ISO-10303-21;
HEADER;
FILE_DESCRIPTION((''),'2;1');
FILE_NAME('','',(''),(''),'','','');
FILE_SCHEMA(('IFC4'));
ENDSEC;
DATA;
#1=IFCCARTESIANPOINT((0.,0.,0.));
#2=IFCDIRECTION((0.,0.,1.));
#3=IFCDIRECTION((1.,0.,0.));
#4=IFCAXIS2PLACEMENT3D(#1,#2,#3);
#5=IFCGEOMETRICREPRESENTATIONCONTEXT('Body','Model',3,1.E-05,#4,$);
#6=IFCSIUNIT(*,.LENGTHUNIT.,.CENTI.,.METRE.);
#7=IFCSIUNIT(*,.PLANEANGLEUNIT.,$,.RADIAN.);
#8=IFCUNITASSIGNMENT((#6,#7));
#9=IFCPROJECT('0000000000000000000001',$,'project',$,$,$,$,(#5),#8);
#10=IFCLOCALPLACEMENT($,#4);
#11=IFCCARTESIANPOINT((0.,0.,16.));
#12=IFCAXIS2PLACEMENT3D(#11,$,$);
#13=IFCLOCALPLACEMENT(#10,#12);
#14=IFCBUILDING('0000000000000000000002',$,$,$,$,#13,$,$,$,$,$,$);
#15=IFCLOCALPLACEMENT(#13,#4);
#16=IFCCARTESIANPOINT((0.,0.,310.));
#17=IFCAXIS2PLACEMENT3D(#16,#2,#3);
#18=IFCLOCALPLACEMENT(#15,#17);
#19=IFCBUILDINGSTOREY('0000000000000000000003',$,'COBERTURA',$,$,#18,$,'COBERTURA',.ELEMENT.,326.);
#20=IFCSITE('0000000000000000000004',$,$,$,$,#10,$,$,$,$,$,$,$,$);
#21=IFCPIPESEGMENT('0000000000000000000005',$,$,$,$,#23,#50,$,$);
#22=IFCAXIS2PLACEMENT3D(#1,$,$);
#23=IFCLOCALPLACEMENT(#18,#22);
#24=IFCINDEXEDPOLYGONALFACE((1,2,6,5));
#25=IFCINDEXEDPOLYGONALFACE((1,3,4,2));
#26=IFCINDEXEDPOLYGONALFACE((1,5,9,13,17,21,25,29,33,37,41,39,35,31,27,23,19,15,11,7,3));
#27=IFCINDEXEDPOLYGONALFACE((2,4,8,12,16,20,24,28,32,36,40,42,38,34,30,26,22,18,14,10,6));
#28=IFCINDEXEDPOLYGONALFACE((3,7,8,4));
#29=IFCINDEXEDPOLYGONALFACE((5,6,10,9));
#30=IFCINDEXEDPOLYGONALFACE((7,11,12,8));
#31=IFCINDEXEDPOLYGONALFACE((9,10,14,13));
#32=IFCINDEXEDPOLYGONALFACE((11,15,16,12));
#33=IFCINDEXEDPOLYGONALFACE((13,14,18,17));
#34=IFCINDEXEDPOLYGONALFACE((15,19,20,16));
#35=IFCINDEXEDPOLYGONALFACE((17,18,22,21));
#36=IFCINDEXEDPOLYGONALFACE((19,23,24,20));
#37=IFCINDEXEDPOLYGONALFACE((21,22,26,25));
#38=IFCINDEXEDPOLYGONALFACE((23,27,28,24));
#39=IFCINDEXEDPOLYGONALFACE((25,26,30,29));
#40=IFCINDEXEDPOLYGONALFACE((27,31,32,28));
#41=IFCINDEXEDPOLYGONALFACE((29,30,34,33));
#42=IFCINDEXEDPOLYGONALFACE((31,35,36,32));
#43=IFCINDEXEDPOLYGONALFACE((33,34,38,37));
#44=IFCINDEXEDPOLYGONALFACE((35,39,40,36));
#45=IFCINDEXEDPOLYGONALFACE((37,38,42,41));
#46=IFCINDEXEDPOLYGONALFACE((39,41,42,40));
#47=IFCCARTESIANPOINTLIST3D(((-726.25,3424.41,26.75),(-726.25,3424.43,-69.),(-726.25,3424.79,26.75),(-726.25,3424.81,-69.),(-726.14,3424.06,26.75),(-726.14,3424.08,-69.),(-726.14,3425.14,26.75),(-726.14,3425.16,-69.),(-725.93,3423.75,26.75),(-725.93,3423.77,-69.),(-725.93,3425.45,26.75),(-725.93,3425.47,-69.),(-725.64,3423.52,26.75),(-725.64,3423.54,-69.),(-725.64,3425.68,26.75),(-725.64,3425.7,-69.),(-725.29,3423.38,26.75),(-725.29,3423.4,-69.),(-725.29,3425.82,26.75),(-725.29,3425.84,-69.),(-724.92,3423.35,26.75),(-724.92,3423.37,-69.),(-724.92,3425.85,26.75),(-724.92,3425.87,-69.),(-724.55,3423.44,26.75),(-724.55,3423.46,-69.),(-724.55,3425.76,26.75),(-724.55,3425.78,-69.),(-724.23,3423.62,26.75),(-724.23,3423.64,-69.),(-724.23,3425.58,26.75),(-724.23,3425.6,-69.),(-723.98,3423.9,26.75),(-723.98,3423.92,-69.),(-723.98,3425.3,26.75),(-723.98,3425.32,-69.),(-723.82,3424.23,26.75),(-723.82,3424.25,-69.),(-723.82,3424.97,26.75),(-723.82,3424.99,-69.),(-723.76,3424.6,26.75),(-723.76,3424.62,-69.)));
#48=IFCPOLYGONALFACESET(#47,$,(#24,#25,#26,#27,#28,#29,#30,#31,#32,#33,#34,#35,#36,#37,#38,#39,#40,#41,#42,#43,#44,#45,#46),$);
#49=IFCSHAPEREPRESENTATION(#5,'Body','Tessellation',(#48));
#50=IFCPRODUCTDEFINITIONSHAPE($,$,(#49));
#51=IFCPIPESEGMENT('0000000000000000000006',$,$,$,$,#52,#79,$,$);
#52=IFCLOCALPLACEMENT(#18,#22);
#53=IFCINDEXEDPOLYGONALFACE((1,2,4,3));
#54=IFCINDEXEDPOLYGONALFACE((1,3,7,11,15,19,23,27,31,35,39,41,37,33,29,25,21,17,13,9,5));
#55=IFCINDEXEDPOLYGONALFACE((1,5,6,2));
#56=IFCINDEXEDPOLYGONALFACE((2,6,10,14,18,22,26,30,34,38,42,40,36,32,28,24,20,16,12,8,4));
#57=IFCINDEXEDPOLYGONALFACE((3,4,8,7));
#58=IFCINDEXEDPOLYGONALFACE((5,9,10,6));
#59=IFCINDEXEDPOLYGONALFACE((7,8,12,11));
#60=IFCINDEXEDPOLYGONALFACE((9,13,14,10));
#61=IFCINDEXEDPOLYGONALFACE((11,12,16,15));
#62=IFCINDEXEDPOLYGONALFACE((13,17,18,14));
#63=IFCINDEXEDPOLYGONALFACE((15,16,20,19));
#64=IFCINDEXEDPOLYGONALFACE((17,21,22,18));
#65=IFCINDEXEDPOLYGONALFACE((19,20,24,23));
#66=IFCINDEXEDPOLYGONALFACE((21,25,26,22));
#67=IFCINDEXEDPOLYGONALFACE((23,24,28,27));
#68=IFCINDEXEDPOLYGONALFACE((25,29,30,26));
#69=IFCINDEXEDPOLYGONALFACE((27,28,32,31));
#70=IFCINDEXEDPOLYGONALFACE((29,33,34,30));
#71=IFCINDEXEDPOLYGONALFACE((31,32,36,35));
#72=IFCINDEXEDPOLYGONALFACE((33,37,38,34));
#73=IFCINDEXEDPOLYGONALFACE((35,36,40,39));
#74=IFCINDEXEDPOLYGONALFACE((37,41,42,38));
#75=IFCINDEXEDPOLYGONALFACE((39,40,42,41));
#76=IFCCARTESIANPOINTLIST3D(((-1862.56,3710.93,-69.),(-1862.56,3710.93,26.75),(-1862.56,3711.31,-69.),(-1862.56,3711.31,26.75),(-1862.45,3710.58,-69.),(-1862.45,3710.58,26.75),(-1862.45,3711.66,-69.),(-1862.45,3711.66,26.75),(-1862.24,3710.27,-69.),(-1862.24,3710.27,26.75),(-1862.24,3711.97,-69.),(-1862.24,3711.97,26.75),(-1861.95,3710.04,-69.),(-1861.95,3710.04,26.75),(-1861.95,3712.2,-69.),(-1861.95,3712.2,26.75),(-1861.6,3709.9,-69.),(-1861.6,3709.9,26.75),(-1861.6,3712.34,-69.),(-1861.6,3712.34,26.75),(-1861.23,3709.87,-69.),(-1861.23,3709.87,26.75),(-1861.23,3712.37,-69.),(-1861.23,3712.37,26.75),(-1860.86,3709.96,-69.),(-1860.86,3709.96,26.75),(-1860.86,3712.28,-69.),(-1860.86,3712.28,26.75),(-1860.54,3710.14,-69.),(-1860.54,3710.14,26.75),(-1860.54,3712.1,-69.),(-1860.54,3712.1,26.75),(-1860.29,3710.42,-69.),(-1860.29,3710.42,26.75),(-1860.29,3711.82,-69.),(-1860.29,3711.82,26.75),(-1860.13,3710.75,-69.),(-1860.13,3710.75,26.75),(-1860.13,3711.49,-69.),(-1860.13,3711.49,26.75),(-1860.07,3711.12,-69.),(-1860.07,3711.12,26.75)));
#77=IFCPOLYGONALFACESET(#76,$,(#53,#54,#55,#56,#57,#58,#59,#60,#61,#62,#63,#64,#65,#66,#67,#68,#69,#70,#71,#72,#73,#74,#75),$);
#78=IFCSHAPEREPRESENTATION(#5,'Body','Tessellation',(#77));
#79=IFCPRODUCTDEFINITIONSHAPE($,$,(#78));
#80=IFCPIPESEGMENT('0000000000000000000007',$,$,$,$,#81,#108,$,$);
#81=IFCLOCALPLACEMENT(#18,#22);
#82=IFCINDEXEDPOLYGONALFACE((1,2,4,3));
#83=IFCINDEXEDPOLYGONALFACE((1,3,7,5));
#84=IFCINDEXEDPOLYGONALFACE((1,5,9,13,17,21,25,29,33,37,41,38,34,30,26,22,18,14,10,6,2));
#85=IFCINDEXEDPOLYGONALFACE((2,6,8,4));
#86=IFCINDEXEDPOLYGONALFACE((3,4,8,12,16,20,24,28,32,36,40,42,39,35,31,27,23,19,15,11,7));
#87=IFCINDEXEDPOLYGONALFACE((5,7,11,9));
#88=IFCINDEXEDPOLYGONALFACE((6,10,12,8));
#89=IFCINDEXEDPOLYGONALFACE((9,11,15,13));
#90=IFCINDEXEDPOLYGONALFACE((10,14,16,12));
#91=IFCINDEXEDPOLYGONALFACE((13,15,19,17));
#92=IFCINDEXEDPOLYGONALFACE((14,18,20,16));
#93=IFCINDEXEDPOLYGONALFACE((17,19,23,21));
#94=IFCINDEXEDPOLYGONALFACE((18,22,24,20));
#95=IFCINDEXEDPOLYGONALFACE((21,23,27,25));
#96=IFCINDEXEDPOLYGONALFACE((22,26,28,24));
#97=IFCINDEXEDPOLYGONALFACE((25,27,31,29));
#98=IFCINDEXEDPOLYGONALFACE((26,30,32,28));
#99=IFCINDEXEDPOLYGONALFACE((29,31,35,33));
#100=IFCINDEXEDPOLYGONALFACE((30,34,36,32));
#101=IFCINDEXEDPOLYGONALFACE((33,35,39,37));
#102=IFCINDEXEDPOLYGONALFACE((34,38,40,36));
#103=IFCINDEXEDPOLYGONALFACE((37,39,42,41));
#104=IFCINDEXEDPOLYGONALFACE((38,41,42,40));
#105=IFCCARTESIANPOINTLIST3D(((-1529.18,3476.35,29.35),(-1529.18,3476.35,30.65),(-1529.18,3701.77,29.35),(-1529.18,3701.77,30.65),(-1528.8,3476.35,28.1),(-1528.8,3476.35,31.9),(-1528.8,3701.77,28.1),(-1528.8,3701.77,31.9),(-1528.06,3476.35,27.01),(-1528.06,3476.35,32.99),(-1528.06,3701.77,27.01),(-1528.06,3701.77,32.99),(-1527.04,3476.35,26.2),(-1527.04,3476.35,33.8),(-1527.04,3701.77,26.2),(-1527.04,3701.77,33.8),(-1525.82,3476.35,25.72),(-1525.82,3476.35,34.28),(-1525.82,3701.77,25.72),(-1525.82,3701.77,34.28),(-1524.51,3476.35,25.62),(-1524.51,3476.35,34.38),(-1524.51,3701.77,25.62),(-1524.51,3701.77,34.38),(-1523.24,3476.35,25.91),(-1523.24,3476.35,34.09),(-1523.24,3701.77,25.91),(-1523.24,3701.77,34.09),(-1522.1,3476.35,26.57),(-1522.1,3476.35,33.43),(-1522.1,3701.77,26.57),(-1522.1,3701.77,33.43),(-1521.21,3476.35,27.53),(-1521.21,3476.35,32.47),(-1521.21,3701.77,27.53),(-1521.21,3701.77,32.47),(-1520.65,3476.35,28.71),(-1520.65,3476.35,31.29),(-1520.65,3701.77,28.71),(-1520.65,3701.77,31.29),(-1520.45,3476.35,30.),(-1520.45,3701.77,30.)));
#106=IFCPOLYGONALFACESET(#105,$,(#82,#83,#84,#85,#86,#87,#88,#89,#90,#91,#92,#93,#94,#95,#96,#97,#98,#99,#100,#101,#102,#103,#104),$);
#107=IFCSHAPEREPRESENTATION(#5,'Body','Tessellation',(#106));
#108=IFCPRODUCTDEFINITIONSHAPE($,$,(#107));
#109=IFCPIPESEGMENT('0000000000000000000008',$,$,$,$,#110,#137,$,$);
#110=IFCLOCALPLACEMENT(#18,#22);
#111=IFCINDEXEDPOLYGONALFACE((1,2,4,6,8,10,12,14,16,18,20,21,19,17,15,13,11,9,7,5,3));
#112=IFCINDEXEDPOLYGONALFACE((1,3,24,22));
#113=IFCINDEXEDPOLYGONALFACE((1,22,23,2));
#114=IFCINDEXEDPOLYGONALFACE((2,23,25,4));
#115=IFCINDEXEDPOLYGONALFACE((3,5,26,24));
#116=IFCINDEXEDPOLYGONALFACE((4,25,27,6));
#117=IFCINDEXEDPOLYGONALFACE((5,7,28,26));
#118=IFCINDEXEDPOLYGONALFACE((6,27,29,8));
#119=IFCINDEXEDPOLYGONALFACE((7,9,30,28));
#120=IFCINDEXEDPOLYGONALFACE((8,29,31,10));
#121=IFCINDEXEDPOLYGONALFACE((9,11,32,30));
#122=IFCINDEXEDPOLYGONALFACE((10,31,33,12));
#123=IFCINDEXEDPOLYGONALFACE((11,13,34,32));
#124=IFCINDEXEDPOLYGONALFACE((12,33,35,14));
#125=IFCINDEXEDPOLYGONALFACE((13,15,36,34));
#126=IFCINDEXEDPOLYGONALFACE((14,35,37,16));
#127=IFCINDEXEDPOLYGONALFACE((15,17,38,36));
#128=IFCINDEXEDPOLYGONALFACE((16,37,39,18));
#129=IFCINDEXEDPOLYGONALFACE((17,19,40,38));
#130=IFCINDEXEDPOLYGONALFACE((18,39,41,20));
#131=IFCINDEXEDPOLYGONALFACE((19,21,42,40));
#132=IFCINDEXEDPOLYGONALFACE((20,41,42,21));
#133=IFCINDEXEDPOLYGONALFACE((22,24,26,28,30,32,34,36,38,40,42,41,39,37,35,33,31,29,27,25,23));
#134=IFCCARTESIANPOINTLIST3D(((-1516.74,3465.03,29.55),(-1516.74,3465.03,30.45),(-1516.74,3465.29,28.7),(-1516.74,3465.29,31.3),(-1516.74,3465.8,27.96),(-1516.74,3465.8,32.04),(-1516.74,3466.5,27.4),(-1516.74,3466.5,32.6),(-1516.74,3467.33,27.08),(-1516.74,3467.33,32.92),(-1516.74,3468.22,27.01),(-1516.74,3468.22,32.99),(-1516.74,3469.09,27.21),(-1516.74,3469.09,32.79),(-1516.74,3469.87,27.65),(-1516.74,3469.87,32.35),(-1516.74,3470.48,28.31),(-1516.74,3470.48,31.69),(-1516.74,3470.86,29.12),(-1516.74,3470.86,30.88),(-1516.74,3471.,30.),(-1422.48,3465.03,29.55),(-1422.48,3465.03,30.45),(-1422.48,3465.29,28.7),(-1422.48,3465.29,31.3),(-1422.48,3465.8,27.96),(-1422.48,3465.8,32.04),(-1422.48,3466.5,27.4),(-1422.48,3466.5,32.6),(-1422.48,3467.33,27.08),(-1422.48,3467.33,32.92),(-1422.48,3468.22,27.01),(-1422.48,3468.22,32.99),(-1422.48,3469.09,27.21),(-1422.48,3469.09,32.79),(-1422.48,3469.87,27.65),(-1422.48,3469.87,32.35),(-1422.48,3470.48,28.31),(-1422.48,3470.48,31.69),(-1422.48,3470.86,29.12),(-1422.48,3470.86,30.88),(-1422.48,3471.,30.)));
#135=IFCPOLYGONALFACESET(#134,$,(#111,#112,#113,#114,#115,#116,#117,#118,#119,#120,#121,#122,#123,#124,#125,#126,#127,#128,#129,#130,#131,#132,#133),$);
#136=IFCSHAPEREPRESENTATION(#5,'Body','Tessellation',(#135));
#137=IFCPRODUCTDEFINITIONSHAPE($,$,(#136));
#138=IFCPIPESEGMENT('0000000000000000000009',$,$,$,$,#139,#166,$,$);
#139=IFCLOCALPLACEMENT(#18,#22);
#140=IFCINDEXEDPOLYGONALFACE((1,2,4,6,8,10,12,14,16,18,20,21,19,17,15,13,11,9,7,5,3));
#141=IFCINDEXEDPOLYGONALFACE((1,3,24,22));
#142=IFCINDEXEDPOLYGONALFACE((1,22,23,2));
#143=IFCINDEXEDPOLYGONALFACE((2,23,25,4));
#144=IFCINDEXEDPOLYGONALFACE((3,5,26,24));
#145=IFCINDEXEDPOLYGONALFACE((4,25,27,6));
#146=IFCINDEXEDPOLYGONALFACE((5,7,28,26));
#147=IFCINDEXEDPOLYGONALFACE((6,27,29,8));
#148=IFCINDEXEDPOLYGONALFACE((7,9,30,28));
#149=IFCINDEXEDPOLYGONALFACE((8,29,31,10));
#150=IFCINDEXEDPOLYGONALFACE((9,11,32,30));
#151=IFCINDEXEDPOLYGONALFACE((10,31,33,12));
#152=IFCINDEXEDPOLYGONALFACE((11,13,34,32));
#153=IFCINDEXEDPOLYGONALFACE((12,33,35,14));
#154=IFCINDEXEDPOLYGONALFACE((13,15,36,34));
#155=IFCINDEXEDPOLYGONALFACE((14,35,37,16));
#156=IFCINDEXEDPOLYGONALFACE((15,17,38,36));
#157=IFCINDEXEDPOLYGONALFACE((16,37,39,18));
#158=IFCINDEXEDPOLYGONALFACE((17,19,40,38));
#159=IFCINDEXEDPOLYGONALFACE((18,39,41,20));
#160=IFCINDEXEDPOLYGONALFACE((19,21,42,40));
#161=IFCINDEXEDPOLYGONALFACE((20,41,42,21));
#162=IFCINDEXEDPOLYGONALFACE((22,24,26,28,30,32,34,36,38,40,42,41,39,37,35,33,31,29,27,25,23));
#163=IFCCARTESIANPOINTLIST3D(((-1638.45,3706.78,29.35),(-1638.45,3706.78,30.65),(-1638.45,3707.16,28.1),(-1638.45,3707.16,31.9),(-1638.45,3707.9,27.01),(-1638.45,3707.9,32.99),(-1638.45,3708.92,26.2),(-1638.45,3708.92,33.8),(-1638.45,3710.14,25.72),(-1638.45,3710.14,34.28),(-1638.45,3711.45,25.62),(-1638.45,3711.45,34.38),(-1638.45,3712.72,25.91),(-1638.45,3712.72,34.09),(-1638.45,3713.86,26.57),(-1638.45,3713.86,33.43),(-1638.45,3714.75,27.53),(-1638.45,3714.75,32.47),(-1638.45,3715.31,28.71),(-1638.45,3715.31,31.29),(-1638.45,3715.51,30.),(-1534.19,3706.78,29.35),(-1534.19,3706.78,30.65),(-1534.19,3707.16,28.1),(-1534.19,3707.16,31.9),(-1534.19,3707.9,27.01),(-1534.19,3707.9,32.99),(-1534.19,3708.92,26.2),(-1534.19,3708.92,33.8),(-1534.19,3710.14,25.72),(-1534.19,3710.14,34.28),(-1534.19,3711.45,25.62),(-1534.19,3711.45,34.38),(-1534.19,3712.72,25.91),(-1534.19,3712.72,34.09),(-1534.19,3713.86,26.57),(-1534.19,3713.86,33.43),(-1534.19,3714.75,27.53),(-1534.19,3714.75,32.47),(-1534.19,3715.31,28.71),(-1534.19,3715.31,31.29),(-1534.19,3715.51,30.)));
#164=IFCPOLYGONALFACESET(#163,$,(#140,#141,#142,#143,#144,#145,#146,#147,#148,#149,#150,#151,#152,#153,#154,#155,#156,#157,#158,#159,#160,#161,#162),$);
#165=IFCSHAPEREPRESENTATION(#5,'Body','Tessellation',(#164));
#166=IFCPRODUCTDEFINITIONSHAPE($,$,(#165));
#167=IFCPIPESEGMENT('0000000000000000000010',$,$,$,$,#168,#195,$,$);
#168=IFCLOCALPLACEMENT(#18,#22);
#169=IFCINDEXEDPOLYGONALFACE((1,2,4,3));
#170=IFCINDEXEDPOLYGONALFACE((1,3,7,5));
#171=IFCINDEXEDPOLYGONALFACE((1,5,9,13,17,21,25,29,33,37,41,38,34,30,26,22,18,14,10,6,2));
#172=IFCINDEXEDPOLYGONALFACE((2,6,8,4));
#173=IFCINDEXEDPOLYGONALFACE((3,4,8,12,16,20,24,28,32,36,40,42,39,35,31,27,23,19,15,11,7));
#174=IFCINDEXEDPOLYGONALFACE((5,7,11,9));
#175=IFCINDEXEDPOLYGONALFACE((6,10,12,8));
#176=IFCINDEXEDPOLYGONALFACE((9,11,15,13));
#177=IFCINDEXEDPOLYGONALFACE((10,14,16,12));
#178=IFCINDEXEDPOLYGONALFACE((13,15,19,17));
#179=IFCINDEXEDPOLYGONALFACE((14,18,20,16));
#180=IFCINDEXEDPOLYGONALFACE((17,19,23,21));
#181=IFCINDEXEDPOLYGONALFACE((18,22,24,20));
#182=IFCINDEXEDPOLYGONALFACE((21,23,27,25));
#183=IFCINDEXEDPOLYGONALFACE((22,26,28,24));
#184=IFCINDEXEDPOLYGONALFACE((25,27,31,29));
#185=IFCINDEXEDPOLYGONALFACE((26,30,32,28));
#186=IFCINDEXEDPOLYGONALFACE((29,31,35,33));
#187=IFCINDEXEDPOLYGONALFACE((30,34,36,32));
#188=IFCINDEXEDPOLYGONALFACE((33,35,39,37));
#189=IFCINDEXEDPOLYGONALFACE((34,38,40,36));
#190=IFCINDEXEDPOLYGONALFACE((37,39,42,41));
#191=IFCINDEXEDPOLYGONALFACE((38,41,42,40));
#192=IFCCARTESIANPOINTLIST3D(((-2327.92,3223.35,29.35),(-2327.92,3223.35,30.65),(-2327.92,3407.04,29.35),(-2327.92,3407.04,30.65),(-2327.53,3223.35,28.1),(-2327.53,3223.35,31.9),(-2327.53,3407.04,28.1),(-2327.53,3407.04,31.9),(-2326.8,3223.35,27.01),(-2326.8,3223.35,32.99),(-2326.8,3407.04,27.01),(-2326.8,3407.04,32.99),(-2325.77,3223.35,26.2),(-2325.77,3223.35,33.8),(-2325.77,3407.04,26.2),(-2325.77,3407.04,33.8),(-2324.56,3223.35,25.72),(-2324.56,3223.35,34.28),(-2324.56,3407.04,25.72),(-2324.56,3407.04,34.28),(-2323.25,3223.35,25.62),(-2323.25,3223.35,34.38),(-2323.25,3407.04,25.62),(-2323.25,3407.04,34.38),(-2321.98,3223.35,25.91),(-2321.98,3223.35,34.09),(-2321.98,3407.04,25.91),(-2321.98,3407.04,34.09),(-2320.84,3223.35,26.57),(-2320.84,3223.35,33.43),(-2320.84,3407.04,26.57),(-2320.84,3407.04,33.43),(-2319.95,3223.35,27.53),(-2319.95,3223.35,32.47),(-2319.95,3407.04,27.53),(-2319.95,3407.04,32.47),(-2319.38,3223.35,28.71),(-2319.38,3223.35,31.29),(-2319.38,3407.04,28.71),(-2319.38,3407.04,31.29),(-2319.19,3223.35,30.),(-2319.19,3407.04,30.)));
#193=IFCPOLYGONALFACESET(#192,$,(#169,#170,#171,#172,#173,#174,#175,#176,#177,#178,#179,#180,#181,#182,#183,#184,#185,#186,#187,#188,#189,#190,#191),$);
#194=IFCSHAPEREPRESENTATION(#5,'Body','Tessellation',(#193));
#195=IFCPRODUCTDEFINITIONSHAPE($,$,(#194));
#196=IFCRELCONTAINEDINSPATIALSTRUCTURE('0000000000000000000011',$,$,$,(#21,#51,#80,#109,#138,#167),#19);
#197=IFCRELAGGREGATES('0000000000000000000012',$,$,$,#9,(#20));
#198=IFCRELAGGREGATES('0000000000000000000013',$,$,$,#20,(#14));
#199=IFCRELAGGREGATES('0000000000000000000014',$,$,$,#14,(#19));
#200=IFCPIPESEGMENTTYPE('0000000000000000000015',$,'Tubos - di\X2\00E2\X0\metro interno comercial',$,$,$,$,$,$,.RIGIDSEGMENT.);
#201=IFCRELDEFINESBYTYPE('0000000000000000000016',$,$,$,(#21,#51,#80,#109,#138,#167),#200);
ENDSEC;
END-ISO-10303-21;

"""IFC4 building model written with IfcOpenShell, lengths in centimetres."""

from ifc_helpers import new_model, si_unit, frame, origin_with_axes, origin_2d_with_axis, place, context, project, spatial, circle, extrude, type_object, element, save


model = new_model("IFC4")

# Units and contexts
model_context = context("Model", 3, precision=1e-05, world=origin_with_axes(), identifier="Body")
ifc_project = project(units=[si_unit("LENGTHUNIT", "METRE", prefix="CENTI"), si_unit("PLANEANGLEUNIT", "RADIAN")], contexts=[model_context])

# Site, building, storey
site_placement = place(None, origin_with_axes())
site = spatial("IfcSite", under=ifc_project, at=site_placement)
building_placement = place(site_placement, frame((0.0, 0.0, 16.0)))
building = spatial("IfcBuilding", under=site, at=building_placement)
placement = place(building_placement, origin_with_axes())
storey_placement = place(placement, frame((0.0, 0.0, 310.0), z_axis=(0.0, 0.0, 1.0), x_axis=(1.0, 0.0, 0.0)))
storey = spatial("IfcBuildingStorey", under=building, at=storey_placement, Name="COBERTURA", LongName="COBERTURA", CompositionType="ELEMENT", Elevation=326.0)

# Pipe segments
pipe_segment_type = type_object("IfcPipeSegmentType", Name="Tubos - diâmetro interno comercial", PredefinedType="RIGIDSEGMENT")
pipe_segment_1_placement = place(storey_placement, frame((-725.01, 3424.61, 26.75), z_axis=(0.0, 0.0, 1.0), x_axis=(1.0, 0.0, 0.0)))
element("IfcPipeSegment", 1, at=pipe_segment_1_placement, inside=storey, type_object=pipe_segment_type, context=model_context, shape_type="SolidModel", body=[
    extrude(circle(Radius=1.25, at=origin_2d_with_axis()), frame((0.0, -0.01, 0.0), z_axis=(0.0, 0.000204, -1.0), x_axis=(1.0, 0.0, 0.0)), (0.0, 0.0, 1.0), 95.75),
])
pipe_segment_2_placement = place(storey_placement, frame((-1861.32, 3711.12, 26.75), z_axis=(0.0, 0.0, 1.0), x_axis=(1.0, 0.0, 0.0)))
element("IfcPipeSegment", 2, at=pipe_segment_2_placement, inside=storey, type_object=pipe_segment_type, context=model_context, shape_type="SolidModel", body=[
    extrude(circle(Radius=1.25, at=origin_2d_with_axis()), frame((0.0, 0.0, 0.0), z_axis=(0.0, 0.0, -1.0), x_axis=(1.0, 0.0, 0.0)), (0.0, 0.0, 1.0), 95.75),
])
pipe_segment_3_placement = place(storey_placement, frame((-1524.84, 3589.06, 34.39), z_axis=(0.0, 0.0, 1.0), x_axis=(1.0, 0.0, 0.0)))
element("IfcPipeSegment", 3, at=pipe_segment_3_placement, inside=storey, type_object=pipe_segment_type, context=model_context, shape_type="SolidModel", body=[
    extrude(circle(Radius=4.39, at=origin_2d_with_axis()), frame((0.0, -112.71, -4.39), z_axis=(0.0, 1.0, 0.0), x_axis=(1.0, 0.0, 0.0)), (0.0, 0.0, 1.0), 225.42),
])
pipe_segment_4_placement = place(storey_placement, frame((-1469.61, 3468.0, 33.0), z_axis=(0.0, 0.0, 1.0), x_axis=(1.0, 0.0, 0.0)))
element("IfcPipeSegment", 4, at=pipe_segment_4_placement, inside=storey, type_object=pipe_segment_type, context=model_context, shape_type="SolidModel", body=[
    extrude(circle(Radius=3.0, at=origin_2d_with_axis()), frame((-47.13, 0.0, -3.0), z_axis=(1.0, 0.0, 0.0), x_axis=(0.0, 1.0, 0.0)), (0.0, 0.0, 1.0), 94.26),
])
pipe_segment_5_placement = place(storey_placement, frame((-1586.32, 3711.12, 34.39), z_axis=(0.0, 0.0, 1.0), x_axis=(1.0, 0.0, 0.0)))
element("IfcPipeSegment", 5, at=pipe_segment_5_placement, inside=storey, type_object=pipe_segment_type, context=model_context, shape_type="SolidModel", body=[
    extrude(circle(Radius=4.39, at=origin_2d_with_axis()), frame((52.13, 0.0, -4.39), z_axis=(-1.0, 0.0, 0.0), x_axis=(0.0, 1.0, 0.0)), (0.0, 0.0, 1.0), 104.26),
])
pipe_segment_6_placement = place(storey_placement, frame((-2323.58, 3315.19, 34.39), z_axis=(0.0, 0.0, 1.0), x_axis=(1.0, 0.0, 0.0)))
element("IfcPipeSegment", 6, at=pipe_segment_6_placement, inside=storey, type_object=pipe_segment_type, context=model_context, shape_type="SolidModel", body=[
    extrude(circle(Radius=4.39, at=origin_2d_with_axis()), frame((0.0, -91.85, -4.39), z_axis=(0.0, 1.0, 0.0), x_axis=(1.0, 0.0, 0.0)), (0.0, 0.0, 1.0), 183.69),
])

save(model, "model.ifc")
